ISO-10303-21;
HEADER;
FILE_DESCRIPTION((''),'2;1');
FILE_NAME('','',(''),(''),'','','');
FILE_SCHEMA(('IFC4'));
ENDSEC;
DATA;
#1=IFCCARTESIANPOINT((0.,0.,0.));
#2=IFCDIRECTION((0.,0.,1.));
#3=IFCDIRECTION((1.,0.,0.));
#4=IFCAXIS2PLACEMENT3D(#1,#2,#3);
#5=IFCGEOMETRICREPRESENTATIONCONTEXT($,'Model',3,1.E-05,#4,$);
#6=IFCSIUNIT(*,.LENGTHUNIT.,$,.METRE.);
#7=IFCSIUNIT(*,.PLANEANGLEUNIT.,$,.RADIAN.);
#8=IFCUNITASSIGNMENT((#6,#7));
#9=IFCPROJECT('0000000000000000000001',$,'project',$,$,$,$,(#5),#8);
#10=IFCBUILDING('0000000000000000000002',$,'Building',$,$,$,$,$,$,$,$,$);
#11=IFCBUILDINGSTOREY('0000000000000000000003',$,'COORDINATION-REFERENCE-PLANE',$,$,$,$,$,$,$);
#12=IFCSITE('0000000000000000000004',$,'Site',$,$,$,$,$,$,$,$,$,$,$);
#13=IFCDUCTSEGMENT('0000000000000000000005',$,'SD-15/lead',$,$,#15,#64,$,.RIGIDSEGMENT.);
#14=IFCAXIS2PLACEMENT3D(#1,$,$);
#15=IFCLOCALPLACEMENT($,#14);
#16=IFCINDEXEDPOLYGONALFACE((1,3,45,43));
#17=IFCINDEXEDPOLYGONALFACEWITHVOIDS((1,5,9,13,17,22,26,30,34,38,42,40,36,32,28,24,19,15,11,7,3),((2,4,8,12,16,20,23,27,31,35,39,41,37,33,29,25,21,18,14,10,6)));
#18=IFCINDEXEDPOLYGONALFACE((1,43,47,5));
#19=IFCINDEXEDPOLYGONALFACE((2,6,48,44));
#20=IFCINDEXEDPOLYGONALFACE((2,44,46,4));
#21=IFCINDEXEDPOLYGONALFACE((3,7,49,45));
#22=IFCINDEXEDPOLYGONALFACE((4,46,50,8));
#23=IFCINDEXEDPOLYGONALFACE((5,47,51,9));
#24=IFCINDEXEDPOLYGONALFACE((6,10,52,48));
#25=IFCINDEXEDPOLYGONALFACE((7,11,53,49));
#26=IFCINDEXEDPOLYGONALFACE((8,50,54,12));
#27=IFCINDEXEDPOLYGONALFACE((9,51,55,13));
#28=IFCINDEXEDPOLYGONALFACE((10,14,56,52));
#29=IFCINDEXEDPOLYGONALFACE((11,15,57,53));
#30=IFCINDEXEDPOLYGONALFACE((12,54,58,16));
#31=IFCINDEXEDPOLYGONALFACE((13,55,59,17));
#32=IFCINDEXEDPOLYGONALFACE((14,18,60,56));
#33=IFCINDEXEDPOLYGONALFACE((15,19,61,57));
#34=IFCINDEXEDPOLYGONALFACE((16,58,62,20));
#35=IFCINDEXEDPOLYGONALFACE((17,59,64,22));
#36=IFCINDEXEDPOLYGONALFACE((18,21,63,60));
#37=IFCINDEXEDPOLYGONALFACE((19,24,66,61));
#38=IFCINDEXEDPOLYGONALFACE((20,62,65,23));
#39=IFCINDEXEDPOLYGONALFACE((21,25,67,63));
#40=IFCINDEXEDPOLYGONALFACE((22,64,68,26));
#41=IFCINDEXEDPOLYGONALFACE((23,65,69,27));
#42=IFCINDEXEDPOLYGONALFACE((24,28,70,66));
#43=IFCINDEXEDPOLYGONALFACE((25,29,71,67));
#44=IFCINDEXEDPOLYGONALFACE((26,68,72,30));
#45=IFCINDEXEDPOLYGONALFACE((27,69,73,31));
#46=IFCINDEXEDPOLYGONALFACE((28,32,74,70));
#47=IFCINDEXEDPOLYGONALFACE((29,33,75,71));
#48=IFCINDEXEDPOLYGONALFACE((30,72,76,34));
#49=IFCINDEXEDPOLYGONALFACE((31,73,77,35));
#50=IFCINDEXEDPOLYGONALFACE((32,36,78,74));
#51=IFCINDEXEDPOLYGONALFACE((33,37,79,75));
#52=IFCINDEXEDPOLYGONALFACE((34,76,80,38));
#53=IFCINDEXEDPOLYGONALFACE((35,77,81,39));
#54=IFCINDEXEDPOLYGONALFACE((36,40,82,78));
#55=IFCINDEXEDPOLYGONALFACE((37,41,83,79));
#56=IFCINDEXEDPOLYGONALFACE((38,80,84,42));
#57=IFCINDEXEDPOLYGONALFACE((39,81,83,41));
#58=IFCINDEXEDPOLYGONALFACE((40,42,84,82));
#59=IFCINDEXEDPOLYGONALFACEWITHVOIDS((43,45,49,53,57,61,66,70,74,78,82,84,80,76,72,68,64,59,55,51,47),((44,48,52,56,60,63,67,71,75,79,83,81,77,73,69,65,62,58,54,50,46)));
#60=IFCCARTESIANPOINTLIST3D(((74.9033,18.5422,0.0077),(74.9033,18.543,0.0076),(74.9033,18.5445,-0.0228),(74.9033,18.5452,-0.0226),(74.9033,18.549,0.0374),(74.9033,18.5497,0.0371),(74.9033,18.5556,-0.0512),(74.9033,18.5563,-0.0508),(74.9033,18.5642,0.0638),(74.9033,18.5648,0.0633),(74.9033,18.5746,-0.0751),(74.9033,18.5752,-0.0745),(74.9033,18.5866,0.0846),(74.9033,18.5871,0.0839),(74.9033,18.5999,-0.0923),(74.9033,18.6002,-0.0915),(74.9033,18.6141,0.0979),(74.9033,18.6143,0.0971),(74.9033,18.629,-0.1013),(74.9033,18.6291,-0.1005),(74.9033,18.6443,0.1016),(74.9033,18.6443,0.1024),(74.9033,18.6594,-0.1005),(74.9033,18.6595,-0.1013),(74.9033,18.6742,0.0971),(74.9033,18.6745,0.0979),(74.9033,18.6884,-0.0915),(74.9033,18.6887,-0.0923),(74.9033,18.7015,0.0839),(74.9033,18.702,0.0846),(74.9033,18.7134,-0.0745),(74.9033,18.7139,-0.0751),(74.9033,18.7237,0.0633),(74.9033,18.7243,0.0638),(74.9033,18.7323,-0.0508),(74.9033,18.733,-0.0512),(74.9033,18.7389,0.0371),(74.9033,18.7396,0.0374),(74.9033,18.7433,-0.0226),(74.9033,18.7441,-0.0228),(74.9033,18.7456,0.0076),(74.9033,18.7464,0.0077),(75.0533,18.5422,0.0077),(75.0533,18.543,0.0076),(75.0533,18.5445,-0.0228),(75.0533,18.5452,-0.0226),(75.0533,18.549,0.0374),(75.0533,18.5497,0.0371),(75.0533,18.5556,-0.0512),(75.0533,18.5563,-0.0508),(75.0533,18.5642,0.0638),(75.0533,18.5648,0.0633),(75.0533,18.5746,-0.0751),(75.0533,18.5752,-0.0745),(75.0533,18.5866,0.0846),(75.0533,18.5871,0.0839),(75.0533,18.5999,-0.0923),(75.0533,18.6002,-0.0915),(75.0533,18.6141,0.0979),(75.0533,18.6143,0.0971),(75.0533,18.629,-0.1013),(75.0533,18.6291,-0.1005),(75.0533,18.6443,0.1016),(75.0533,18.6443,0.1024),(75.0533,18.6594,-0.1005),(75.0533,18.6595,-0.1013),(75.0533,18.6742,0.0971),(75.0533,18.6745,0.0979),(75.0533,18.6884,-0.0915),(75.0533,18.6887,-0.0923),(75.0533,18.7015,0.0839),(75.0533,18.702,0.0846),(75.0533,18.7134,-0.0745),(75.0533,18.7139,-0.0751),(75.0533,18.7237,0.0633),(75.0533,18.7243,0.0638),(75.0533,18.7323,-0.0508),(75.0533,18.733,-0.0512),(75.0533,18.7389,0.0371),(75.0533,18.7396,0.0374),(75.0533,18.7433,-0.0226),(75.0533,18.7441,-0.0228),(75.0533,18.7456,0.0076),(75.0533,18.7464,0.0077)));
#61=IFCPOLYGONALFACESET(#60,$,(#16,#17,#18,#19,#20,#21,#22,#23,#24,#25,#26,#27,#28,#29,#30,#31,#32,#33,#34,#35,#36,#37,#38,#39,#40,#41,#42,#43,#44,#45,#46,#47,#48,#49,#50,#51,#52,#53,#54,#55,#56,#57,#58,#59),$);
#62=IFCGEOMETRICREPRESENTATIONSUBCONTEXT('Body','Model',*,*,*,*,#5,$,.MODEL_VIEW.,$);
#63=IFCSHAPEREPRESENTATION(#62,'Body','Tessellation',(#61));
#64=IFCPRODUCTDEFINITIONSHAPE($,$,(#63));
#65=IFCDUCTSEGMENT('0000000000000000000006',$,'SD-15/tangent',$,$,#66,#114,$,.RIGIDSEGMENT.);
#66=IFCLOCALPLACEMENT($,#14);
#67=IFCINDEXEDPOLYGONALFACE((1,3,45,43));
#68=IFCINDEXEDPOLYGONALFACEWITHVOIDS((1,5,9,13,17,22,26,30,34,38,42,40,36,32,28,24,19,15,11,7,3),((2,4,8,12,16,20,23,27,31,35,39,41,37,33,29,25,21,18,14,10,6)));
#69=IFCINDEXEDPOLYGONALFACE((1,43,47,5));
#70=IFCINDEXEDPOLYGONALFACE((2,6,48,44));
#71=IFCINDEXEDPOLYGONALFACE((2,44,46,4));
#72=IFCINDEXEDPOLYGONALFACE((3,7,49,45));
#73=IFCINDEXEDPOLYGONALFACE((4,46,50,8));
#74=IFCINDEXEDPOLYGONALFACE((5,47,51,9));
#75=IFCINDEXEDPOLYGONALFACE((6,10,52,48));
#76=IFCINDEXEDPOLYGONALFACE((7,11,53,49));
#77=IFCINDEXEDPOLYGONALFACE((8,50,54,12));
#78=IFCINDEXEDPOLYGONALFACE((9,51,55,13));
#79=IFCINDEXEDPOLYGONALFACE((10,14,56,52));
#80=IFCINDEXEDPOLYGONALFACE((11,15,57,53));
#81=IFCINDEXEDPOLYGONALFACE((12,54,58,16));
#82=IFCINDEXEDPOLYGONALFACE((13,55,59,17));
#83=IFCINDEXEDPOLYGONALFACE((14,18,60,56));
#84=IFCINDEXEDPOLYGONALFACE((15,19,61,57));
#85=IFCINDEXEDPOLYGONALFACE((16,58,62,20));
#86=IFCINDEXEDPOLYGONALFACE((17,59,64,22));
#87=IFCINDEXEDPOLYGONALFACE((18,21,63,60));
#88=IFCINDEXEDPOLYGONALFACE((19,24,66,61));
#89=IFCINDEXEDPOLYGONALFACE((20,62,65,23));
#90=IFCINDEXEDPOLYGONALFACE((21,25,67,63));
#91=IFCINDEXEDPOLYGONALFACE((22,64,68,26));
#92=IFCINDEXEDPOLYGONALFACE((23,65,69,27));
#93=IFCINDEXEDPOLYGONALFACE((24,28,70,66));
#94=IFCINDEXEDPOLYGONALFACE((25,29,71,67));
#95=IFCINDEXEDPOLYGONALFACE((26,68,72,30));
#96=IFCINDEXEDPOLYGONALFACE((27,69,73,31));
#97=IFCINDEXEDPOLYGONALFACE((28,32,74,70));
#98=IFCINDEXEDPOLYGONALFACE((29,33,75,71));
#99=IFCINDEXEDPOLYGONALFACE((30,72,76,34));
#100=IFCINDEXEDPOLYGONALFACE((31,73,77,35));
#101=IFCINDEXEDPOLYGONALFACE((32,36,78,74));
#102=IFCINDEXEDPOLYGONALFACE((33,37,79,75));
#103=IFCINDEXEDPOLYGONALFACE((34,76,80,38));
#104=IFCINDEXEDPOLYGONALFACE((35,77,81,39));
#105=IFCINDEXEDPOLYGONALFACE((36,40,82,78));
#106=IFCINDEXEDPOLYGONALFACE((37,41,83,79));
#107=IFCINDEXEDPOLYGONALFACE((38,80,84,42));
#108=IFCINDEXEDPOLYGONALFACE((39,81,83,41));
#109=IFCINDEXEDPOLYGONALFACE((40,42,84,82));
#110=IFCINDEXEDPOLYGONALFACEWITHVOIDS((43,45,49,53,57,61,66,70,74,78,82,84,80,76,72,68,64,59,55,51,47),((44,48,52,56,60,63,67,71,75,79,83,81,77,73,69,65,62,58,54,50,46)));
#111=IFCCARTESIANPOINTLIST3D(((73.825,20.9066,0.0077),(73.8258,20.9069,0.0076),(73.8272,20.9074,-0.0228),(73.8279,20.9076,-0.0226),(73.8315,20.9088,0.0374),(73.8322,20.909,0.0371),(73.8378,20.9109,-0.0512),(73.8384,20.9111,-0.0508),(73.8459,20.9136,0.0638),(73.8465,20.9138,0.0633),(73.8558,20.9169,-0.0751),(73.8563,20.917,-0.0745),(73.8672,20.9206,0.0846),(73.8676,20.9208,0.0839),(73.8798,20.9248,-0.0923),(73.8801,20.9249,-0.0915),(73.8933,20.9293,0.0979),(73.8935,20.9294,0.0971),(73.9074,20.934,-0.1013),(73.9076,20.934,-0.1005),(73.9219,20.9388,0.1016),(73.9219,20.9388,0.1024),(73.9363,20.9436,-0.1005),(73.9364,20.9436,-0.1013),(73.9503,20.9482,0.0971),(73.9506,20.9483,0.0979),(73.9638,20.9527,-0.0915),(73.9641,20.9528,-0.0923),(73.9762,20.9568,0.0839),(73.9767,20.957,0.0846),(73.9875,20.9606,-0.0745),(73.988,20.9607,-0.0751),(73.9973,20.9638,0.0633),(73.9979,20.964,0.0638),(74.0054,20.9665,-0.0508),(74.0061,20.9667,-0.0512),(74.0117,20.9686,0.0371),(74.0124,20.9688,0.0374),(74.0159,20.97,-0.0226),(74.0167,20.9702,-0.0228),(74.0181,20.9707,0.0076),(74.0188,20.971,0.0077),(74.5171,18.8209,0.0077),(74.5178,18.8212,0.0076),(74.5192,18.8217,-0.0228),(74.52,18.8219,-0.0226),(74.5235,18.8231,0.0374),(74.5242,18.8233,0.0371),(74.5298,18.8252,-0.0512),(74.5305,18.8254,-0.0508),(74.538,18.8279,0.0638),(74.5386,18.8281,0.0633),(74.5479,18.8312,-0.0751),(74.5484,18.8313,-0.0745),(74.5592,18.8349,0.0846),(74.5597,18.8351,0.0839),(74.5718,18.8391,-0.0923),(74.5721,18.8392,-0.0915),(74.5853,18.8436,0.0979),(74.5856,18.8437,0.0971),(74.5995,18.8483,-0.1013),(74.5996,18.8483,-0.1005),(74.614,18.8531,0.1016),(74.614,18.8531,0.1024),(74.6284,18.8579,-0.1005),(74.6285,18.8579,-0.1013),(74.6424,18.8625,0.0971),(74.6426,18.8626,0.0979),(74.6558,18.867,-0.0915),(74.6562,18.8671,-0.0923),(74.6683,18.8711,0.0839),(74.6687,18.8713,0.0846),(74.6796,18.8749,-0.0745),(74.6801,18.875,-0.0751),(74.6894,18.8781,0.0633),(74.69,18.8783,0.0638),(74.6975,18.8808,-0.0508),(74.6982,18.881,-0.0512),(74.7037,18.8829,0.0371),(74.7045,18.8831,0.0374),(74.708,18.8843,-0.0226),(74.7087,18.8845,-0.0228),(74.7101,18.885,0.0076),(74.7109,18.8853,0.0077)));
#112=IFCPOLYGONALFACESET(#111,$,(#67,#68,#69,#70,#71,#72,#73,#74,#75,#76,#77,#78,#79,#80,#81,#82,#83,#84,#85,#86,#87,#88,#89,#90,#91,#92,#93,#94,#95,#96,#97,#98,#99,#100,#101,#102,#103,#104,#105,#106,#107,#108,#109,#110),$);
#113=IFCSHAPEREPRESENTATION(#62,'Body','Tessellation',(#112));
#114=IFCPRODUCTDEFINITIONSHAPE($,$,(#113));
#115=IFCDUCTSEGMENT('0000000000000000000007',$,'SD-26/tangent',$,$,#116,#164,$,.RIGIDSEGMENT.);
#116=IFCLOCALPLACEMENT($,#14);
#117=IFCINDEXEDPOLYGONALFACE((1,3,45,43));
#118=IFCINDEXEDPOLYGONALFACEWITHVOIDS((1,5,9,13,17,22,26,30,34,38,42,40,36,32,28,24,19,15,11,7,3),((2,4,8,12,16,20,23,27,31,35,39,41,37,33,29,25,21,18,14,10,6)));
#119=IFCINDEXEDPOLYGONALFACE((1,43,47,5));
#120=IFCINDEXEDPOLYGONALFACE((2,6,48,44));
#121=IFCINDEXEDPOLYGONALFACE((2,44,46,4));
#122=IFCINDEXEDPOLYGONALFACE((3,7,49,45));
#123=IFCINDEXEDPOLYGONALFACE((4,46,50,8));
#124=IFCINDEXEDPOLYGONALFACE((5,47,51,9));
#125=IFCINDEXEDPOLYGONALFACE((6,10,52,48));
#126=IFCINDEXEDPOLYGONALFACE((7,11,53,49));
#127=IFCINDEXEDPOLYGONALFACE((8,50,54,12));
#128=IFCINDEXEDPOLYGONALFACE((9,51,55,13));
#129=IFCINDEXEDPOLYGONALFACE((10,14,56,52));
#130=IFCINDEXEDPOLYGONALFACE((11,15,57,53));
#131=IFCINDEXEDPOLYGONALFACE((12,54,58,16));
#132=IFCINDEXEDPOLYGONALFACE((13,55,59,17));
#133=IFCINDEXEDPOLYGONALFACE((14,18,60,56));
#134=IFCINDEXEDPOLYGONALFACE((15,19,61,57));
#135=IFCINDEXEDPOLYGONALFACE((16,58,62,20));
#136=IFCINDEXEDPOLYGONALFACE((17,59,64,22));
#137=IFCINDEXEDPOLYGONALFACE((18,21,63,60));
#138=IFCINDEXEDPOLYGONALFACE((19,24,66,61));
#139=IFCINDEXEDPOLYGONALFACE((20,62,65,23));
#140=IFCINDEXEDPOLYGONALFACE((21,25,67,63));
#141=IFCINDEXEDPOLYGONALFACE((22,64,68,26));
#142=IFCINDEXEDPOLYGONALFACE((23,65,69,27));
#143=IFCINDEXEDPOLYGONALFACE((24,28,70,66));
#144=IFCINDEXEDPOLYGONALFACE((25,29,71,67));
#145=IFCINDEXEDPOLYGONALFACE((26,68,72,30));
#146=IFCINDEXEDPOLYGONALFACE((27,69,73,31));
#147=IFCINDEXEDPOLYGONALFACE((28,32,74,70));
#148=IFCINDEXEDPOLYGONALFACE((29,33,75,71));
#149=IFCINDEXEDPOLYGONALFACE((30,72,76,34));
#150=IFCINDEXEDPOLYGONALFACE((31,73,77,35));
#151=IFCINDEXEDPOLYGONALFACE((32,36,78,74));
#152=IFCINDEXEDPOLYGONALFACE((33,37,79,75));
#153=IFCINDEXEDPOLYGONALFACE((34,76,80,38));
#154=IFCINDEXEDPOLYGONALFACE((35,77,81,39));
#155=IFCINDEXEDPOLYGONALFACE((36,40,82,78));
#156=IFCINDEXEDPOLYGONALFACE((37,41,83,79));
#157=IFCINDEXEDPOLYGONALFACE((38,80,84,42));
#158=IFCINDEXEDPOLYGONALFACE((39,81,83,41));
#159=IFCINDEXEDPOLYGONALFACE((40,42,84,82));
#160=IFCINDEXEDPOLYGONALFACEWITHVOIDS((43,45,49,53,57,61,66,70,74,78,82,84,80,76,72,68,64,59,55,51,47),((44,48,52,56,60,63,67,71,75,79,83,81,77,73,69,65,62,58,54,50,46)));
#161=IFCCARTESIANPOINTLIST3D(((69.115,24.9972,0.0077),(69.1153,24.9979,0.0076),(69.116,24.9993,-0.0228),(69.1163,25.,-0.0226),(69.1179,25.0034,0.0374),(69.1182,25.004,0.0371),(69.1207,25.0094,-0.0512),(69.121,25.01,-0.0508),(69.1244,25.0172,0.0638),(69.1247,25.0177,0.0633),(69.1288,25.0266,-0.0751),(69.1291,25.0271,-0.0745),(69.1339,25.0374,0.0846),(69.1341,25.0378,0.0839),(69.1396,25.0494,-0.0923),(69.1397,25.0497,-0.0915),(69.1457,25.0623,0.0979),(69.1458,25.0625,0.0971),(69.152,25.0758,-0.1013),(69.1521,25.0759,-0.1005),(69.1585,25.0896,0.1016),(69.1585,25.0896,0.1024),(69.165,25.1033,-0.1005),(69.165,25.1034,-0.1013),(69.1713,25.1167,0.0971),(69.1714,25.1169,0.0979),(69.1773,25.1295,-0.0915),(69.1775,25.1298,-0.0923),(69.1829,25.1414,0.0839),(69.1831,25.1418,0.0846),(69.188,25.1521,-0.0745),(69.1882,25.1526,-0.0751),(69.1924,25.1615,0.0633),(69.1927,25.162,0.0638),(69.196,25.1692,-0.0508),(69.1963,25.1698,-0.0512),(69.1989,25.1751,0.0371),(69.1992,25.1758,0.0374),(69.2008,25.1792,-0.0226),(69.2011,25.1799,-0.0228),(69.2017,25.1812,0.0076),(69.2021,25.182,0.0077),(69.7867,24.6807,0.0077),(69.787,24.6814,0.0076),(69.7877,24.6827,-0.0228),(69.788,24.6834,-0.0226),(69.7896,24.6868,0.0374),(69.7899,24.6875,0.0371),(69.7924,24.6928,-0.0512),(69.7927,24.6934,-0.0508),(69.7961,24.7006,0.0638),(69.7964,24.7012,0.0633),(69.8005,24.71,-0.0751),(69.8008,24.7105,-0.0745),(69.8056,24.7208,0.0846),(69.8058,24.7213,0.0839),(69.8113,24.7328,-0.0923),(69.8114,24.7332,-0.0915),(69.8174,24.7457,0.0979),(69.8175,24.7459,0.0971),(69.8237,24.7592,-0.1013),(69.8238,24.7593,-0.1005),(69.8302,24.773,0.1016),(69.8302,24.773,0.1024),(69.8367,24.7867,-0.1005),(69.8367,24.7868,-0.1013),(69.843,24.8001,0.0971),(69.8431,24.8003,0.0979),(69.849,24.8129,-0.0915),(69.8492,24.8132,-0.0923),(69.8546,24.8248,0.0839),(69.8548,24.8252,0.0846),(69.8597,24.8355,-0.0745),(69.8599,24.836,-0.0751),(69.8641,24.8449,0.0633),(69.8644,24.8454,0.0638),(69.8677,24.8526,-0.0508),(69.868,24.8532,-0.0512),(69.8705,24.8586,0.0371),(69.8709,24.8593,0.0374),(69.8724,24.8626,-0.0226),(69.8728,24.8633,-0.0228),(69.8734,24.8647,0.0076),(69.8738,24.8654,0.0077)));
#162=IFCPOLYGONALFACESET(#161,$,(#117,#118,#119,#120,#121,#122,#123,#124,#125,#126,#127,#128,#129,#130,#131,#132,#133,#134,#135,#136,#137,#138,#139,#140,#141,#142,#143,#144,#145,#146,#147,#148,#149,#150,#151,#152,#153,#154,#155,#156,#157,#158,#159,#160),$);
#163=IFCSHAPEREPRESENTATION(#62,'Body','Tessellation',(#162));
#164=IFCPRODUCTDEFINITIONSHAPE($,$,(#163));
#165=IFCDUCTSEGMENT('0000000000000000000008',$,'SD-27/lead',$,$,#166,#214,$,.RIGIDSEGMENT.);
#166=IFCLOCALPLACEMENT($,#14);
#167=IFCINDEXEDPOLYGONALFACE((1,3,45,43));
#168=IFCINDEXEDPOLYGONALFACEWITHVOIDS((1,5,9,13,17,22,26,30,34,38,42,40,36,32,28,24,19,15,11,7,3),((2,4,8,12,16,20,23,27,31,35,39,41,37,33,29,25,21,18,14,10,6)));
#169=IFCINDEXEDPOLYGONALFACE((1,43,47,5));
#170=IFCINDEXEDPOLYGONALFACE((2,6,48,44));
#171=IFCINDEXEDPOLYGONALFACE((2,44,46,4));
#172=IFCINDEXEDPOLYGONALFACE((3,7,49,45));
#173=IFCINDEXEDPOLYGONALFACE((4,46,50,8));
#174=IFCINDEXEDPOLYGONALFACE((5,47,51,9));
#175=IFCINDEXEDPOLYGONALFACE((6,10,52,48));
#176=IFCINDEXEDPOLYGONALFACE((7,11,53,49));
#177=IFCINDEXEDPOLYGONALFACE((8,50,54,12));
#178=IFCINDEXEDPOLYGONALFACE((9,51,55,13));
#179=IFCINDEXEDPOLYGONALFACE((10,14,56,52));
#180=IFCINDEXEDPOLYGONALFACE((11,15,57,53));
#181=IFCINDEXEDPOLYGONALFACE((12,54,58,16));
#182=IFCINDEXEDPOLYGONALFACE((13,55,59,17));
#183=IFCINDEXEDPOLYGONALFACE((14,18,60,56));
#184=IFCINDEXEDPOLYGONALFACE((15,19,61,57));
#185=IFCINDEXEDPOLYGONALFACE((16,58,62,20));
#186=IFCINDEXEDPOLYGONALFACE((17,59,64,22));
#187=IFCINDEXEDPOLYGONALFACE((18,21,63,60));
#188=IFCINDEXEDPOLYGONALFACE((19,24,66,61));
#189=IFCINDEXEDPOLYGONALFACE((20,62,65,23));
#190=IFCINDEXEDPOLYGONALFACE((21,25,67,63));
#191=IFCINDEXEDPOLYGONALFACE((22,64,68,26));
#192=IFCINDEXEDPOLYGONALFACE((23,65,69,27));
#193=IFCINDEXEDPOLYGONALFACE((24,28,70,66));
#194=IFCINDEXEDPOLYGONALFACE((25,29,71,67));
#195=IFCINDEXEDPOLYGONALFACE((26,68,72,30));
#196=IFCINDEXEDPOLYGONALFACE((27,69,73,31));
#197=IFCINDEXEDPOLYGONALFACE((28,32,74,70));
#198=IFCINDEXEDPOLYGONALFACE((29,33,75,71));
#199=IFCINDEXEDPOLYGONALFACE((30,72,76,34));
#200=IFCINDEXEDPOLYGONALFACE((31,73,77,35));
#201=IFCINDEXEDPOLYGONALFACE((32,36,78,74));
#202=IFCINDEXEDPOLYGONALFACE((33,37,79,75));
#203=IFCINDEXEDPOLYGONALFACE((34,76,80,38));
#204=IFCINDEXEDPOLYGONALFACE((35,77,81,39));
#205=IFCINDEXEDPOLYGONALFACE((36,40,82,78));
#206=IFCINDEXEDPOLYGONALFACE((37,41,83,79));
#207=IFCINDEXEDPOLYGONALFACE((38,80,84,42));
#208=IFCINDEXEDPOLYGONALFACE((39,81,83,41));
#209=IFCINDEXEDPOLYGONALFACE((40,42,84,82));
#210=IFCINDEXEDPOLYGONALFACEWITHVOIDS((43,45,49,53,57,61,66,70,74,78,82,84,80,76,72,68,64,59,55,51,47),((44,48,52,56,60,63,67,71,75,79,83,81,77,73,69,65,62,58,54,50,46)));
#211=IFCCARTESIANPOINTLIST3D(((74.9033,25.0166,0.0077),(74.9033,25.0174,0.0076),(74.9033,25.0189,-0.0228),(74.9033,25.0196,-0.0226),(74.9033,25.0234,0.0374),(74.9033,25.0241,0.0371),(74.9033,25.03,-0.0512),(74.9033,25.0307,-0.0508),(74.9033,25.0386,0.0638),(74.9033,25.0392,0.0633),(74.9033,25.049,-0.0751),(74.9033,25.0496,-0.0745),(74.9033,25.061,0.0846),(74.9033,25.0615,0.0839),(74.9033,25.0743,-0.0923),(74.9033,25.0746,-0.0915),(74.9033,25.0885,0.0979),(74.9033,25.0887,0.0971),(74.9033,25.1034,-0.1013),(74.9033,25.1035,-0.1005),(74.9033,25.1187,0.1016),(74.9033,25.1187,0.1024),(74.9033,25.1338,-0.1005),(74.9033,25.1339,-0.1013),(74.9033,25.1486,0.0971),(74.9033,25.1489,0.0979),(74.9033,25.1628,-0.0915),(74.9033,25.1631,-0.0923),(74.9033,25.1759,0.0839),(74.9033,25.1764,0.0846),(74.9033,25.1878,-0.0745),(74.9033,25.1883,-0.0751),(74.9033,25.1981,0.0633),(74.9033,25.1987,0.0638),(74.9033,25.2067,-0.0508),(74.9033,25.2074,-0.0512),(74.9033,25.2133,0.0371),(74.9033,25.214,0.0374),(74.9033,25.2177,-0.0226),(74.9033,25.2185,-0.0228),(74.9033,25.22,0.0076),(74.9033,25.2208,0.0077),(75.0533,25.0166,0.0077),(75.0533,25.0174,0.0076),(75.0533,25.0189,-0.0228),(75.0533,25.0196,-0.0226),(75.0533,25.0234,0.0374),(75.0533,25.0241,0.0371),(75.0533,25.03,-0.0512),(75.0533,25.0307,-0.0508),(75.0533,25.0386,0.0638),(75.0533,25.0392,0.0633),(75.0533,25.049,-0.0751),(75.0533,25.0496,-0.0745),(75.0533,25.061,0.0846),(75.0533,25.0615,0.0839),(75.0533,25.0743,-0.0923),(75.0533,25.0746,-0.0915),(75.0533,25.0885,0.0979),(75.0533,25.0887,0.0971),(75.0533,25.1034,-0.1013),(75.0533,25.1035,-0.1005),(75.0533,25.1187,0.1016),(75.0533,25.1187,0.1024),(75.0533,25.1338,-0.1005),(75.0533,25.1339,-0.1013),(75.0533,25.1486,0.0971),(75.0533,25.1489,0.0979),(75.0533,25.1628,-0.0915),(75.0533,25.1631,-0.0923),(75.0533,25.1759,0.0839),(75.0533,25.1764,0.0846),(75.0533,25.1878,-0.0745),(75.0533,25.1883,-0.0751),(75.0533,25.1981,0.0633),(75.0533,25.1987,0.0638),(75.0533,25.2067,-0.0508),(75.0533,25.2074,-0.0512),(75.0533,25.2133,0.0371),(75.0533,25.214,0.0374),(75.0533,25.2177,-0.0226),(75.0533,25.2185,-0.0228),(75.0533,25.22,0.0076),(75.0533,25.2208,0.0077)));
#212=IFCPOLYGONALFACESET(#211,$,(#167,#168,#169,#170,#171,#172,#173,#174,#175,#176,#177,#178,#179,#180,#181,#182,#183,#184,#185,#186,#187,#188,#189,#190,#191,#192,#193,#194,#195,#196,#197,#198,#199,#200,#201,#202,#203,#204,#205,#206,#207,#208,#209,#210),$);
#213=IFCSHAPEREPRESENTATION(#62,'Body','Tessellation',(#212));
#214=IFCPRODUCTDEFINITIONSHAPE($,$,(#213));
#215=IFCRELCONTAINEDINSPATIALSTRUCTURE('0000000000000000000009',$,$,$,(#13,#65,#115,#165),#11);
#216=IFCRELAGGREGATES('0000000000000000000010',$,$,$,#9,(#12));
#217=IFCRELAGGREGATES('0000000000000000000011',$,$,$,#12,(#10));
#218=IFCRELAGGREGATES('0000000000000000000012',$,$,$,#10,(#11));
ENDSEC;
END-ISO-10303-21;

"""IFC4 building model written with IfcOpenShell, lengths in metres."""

from ifc_helpers import new_model, si_unit, frame, origin_with_axes, place, context, subcontext, project, spatial, hollow_circle, extrude, element, save


model = new_model("IFC4")

# Units and contexts
model_context = context("Model", 3, precision=1e-05, world=origin_with_axes())
body_context_1 = subcontext(model_context, "Body", "Model", "MODEL_VIEW")
ifc_project = project(units=[si_unit("LENGTHUNIT", "METRE"), si_unit("PLANEANGLEUNIT", "RADIAN")], contexts=[model_context])

# Site, building, storey
site = spatial("IfcSite", under=ifc_project, Name="Site")
building = spatial("IfcBuilding", under=site, Name="Building")
storey = spatial("IfcBuildingStorey", under=building, Name="COORDINATION-REFERENCE-PLANE")

# Duct segment
duct_segment_1_placement = place(None, frame((75.0533, 18.6443, 0.0), z_axis=(-1.0, 0.0, 0.0), x_axis=(0.0, 0.0, 1.0)))
element("IfcDuctSegment", 1, at=duct_segment_1_placement, inside=storey, Name="SD-15/lead", PredefinedType="RIGIDSEGMENT", context=body_context_1, shape_type="SweptSolid", body=[
    extrude(hollow_circle(Radius=0.1024, WallThickness=0.0008), origin_with_axes(), (0.0, 0.0, 1.0), 0.15),
])

# Duct segment
duct_segment_2_placement = place(None, frame((74.614, 18.8531, 0.0), z_axis=(-0.314929, 0.949115, 0.0), x_axis=(0.0, 0.0, 1.0)))
element("IfcDuctSegment", 2, at=duct_segment_2_placement, inside=storey, Name="SD-15/tangent", PredefinedType="RIGIDSEGMENT", context=body_context_1, shape_type="SweptSolid", body=[
    extrude(hollow_circle(Radius=0.1024, WallThickness=0.0008), origin_with_axes(), (0.0, 0.0, 1.0), 2.1975),
])

# Duct segment
duct_segment_3_placement = place(None, frame((69.1585, 25.0896, 0.0), z_axis=(0.904569, -0.426327, 0.0), x_axis=(0.0, 0.0, 1.0)))
element("IfcDuctSegment", 3, at=duct_segment_3_placement, inside=storey, Name="SD-26/tangent", PredefinedType="RIGIDSEGMENT", context=body_context_1, shape_type="SweptSolid", body=[
    extrude(hollow_circle(Radius=0.1024, WallThickness=0.0008), origin_with_axes(), (0.0, 0.0, 1.0), 0.7425),
])

# Duct segment
duct_segment_4_placement = place(None, frame((75.0533, 25.1187, 0.0), z_axis=(-1.0, 0.0, 0.0), x_axis=(0.0, 0.0, 1.0)))
element("IfcDuctSegment", 4, at=duct_segment_4_placement, inside=storey, Name="SD-27/lead", PredefinedType="RIGIDSEGMENT", context=body_context_1, shape_type="SweptSolid", body=[
    extrude(hollow_circle(Radius=0.1024, WallThickness=0.0008), origin_with_axes(), (0.0, 0.0, 1.0), 0.15),
])

save(model, "model.ifc")
